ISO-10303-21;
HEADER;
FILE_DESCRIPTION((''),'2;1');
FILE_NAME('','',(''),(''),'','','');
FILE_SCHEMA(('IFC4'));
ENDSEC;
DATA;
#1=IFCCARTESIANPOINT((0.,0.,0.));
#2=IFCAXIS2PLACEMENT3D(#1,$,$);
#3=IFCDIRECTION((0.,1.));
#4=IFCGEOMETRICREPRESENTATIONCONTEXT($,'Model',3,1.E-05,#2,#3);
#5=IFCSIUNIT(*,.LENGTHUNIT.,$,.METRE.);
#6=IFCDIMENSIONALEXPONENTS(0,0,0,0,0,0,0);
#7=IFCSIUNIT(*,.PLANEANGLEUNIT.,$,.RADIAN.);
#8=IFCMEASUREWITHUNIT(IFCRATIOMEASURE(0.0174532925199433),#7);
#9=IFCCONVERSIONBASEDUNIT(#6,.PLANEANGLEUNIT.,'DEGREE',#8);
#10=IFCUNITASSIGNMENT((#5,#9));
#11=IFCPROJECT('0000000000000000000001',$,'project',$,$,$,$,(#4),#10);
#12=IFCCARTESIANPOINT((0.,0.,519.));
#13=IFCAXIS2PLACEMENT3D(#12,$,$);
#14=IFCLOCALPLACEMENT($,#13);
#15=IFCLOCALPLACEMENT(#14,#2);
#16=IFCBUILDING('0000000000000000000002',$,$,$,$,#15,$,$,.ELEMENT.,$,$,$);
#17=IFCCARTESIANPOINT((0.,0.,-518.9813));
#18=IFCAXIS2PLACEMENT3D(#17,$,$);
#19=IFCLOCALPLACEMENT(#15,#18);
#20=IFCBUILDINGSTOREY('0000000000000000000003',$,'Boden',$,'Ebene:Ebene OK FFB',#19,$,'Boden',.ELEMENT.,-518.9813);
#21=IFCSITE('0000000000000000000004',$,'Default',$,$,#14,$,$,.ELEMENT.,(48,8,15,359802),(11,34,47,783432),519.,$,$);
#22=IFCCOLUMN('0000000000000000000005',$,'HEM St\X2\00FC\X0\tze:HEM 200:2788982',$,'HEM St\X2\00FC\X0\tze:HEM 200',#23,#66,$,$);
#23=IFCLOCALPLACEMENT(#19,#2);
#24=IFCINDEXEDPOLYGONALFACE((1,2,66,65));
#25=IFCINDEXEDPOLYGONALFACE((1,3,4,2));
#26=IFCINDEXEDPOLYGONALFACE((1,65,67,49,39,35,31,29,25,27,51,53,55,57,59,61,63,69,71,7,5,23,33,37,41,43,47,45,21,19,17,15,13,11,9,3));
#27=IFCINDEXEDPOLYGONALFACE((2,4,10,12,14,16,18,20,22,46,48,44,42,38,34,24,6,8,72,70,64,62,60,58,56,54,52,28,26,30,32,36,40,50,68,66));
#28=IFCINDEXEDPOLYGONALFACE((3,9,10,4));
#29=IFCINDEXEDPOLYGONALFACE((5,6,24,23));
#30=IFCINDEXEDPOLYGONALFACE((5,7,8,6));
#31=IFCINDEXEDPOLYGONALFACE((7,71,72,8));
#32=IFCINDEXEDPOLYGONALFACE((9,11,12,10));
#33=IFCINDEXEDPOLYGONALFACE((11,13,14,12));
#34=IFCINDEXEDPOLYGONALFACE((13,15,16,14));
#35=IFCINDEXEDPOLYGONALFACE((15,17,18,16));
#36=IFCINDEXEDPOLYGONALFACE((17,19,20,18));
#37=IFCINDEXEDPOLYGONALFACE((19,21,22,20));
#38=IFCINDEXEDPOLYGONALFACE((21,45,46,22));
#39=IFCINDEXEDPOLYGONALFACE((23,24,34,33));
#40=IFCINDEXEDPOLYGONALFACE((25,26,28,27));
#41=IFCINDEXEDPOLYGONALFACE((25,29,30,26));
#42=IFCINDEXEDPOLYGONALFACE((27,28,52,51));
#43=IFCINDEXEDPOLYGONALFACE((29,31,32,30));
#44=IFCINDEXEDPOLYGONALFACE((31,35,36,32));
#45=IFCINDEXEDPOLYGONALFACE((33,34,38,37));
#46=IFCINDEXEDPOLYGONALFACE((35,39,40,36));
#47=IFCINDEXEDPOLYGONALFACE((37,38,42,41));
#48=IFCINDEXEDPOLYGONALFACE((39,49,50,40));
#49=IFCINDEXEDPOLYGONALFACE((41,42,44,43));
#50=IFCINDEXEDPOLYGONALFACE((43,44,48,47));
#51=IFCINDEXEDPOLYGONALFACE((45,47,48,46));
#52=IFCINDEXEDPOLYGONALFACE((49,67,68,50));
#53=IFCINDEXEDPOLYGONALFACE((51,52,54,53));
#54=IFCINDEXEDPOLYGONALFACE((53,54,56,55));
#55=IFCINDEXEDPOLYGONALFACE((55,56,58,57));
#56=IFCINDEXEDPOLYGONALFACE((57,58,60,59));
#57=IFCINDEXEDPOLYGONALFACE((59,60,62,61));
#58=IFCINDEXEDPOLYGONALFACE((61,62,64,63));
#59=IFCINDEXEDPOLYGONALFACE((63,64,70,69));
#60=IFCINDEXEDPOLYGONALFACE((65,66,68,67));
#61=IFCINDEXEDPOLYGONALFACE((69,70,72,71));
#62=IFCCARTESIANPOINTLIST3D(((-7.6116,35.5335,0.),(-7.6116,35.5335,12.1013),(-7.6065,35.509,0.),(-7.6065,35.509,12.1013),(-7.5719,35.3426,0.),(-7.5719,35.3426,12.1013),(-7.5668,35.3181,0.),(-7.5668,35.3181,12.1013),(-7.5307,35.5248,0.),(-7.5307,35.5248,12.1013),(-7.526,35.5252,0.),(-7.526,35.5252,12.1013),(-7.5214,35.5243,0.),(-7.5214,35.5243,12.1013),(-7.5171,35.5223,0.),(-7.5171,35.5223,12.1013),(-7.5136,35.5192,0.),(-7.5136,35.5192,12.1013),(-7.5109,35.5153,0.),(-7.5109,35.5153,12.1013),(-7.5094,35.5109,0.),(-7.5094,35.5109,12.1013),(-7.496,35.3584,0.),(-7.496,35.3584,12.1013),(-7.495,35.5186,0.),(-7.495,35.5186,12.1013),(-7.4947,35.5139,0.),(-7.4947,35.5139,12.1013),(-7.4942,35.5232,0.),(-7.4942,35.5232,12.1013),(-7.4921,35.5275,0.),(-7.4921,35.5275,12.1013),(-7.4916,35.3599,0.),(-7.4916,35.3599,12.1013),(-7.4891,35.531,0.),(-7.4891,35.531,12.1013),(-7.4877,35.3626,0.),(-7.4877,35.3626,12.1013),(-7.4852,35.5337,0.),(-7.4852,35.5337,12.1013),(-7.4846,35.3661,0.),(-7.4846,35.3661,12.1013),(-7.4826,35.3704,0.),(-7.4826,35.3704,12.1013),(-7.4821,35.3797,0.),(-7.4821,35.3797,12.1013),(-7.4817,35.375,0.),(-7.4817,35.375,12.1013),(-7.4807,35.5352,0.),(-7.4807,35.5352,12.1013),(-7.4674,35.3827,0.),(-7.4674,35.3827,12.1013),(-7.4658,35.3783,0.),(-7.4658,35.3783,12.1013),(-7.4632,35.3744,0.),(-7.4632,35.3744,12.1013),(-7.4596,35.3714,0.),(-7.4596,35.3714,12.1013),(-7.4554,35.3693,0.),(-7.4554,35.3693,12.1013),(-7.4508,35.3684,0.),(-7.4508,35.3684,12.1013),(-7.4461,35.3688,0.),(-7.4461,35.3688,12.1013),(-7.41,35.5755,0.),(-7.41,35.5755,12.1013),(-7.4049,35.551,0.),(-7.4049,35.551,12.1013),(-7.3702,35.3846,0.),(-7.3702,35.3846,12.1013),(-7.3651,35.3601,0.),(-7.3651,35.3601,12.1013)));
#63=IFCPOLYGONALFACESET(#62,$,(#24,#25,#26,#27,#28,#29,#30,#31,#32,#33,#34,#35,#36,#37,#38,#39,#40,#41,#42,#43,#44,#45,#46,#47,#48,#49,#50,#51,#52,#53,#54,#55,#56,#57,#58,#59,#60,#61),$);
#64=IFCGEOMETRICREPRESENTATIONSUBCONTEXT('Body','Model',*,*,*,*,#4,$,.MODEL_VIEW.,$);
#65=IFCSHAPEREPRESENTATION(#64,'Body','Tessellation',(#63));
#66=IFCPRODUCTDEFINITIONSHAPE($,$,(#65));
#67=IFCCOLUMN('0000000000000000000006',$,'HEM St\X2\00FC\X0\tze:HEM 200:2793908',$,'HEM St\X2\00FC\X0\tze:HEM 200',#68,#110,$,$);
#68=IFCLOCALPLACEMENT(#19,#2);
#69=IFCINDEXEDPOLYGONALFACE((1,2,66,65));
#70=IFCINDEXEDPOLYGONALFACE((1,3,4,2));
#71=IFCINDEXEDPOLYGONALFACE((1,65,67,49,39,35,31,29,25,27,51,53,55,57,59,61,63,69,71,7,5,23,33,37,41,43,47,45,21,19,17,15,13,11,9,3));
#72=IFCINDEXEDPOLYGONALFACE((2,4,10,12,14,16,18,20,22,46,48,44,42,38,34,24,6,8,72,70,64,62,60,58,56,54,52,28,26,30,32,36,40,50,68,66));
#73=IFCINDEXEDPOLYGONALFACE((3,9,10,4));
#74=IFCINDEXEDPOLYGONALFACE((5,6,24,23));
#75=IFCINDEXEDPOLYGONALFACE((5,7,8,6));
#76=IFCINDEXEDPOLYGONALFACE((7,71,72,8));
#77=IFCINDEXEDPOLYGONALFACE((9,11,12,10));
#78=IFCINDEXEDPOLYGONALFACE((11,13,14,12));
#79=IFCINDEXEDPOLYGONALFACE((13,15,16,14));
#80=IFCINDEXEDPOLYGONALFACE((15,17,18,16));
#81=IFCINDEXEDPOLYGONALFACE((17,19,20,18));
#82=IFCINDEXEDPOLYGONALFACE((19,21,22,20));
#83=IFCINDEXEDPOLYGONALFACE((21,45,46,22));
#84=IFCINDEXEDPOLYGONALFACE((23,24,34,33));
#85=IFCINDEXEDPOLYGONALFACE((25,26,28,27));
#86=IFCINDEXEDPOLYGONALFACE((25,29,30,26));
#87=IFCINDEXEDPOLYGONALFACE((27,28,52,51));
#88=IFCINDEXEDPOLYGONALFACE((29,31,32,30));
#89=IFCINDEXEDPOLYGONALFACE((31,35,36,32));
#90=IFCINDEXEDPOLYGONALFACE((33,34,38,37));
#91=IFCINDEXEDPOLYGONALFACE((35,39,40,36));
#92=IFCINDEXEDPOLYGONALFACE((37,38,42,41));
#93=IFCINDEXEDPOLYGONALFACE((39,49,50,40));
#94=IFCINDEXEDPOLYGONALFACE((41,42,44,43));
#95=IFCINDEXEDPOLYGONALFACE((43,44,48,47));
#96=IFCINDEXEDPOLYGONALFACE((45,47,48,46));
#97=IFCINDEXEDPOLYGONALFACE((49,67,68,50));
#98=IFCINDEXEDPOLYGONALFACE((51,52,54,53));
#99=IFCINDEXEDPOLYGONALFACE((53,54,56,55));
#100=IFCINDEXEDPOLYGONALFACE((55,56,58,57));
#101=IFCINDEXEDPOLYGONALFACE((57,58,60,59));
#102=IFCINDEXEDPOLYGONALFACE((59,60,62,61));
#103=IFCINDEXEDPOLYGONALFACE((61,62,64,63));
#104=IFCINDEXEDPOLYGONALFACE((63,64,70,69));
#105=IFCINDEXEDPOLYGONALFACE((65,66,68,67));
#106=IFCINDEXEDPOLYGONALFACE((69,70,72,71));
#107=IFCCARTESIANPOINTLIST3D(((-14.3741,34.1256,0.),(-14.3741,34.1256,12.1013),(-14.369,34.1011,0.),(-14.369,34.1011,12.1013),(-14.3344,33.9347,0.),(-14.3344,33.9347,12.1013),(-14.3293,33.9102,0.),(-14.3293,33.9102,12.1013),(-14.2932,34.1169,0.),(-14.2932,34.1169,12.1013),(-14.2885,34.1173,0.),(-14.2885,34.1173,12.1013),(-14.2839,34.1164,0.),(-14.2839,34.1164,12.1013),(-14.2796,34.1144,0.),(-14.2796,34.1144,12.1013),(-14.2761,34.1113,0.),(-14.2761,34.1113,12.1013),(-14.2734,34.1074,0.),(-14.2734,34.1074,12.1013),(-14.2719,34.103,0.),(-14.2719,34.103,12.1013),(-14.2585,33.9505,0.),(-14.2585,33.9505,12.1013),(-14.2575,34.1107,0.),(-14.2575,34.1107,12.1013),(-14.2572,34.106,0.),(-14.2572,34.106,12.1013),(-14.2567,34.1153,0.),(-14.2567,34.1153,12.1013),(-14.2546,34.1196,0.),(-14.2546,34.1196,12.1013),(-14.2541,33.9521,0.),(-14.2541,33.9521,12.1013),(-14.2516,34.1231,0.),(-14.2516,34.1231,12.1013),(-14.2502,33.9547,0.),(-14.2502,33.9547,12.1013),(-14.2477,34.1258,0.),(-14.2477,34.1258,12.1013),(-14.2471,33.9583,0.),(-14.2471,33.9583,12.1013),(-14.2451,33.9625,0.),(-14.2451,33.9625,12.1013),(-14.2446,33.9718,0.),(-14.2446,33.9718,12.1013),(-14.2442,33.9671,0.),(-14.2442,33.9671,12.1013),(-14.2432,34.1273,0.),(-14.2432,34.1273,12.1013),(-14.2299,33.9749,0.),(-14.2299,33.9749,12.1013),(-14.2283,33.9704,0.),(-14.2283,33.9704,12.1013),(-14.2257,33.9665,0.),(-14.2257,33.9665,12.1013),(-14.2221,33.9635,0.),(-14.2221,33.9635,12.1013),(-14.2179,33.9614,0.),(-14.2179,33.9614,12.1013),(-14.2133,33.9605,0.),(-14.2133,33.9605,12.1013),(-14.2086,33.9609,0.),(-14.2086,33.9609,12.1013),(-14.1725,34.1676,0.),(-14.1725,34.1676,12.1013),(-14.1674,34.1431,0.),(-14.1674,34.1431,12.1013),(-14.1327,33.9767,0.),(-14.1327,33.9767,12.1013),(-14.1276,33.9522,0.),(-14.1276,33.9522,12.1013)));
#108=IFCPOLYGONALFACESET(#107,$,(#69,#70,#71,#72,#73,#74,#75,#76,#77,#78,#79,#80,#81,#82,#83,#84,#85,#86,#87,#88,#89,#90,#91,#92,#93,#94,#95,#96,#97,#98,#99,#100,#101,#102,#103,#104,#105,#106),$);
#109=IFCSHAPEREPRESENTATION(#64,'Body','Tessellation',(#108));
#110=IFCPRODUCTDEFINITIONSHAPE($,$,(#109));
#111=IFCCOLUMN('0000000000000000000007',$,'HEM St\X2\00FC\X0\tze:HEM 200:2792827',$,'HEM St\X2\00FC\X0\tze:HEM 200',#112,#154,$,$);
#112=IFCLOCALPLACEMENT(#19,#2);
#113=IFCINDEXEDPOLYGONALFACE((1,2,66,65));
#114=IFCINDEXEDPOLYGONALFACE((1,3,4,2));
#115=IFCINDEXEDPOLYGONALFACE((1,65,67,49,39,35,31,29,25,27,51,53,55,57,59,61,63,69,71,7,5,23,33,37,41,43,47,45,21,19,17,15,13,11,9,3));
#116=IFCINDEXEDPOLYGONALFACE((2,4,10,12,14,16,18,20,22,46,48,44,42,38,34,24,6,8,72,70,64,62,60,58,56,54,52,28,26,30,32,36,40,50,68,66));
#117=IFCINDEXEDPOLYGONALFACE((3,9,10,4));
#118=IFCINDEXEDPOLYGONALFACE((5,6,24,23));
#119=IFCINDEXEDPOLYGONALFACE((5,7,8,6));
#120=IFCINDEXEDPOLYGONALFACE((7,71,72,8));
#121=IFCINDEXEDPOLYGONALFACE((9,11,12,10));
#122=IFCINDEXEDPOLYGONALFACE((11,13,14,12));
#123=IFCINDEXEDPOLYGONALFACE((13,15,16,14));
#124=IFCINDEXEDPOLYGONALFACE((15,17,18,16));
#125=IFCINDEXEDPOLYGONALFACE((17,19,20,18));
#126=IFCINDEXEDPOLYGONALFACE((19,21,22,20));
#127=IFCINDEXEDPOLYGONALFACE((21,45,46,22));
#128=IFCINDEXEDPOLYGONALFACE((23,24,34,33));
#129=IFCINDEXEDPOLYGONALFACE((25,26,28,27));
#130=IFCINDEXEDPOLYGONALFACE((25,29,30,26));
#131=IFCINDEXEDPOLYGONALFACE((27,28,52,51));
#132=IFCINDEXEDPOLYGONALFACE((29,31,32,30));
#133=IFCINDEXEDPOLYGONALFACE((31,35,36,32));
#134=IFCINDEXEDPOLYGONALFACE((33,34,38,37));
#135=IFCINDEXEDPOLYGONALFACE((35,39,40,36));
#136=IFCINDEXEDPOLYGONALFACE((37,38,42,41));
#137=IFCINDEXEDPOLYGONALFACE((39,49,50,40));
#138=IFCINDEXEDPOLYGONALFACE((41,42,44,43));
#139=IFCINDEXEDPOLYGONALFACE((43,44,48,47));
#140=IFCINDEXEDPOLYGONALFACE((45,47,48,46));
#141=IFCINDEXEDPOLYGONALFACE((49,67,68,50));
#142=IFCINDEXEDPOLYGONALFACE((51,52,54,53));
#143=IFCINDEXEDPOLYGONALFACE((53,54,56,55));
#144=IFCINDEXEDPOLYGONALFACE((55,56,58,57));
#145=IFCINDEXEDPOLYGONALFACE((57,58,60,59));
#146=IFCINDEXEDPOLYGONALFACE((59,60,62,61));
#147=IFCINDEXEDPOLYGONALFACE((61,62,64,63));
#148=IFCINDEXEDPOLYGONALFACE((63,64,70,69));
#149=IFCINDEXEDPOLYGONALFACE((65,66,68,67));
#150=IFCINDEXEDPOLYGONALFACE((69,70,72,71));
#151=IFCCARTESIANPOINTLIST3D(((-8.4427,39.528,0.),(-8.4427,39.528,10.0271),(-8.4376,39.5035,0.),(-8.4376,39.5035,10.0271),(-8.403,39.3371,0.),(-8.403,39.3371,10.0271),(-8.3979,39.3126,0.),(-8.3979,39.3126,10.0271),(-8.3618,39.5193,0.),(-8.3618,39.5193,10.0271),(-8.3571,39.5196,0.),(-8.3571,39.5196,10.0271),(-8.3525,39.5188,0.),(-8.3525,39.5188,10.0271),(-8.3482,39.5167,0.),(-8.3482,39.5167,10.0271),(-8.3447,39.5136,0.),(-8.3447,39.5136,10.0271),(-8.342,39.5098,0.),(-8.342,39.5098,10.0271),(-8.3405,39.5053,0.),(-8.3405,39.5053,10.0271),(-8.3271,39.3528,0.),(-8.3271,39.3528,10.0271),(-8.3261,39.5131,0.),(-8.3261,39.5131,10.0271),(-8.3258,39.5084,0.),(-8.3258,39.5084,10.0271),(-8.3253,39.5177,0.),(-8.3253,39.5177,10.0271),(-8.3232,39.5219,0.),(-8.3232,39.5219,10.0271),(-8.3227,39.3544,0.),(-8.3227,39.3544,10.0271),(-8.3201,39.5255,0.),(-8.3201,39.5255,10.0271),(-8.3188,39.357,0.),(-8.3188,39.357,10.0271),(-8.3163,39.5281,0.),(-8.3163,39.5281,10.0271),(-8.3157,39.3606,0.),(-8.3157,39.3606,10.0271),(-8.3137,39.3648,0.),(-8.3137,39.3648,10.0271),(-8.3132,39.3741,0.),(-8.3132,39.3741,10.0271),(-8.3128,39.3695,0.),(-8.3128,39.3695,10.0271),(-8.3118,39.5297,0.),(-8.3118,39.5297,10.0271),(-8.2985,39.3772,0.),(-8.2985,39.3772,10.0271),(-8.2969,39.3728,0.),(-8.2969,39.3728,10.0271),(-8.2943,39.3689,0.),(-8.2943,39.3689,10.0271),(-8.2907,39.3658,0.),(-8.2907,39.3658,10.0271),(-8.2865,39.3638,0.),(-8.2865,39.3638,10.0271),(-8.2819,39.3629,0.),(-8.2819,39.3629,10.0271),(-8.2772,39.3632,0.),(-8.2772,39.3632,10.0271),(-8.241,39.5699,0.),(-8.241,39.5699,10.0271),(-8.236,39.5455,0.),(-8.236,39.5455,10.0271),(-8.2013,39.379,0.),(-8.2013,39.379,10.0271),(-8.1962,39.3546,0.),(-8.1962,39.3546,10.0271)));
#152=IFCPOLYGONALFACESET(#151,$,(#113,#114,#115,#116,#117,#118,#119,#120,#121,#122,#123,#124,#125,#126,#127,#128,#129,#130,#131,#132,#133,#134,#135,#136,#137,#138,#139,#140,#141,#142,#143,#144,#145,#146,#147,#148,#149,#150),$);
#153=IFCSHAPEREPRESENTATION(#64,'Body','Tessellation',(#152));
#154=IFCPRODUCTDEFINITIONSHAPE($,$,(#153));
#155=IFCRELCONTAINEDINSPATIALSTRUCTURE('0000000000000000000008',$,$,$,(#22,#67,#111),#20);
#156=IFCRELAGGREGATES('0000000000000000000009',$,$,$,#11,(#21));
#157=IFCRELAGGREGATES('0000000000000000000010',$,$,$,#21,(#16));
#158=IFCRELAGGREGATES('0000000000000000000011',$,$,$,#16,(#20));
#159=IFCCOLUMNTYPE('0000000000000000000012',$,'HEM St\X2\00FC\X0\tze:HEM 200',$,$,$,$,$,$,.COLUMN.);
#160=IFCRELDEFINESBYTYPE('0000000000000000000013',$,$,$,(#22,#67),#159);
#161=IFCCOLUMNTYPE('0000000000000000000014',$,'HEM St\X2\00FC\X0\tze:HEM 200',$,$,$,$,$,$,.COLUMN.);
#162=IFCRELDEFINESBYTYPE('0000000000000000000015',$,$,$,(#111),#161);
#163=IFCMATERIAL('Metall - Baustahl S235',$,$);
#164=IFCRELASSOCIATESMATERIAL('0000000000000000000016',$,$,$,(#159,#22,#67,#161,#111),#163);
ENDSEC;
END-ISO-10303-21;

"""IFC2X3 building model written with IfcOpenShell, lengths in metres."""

from ifc_helpers import new_model, entity, si_unit, converted_unit, direction, frame, frame_2d, origin, place, context, subcontext, project, spatial, polyline, circle_curve, parameter, trimmed, segment, composite_curve, outline, extrude, source, transform, mapped, material, type_object, type_shapes, element, save


model = new_model("IFC2X3")

# Units and contexts
model_context = context("Model", 3, precision=1e-05, world=origin(), true_north=direction((0.0, 1.0)))
body_context = subcontext(model_context, "Body", "Model", "MODEL_VIEW")
ifc_project = project(units=[si_unit("LENGTHUNIT", "METRE"), converted_unit("PLANEANGLEUNIT", "DEGREE", entity("IfcRatioMeasure", 0.0174532925199433), si_unit("PLANEANGLEUNIT", "RADIAN"), dimensions=[0, 0, 0, 0, 0, 0, 0])], contexts=[model_context])

# Site, building, storey
site_placement = place(None, frame((0.0, 0.0, 519.0)))
site = spatial("IfcSite", under=ifc_project, at=site_placement, Name="Default", CompositionType="ELEMENT", RefLatitude=(48, 8, 15, 359802), RefLongitude=(11, 34, 47, 783432), RefElevation=519.0)
building_placement = place(site_placement, origin())
building = spatial("IfcBuilding", under=site, at=building_placement, CompositionType="ELEMENT")
storey_placement = place(building_placement, frame((0.0, 0.0, -518.9813)))
storey = spatial("IfcBuildingStorey", under=building, at=storey_placement, Name="Boden", ObjectType="Ebene:Ebene OK FFB", LongName="Boden", CompositionType="ELEMENT", Elevation=-518.9813)

# Columns
ifc_material = material(Name="Metall - Baustahl S235")
column_type_1 = type_object("IfcColumnType", Name="HEM Stütze:HEM 200", PredefinedType="COLUMN", material=ifc_material)
shared_shape_1 = source(origin(), body_context, "Body", "SweptSolid", [
    extrude(outline(composite_curve([segment(polyline([(0.085, -0.103), (0.11, -0.103)]), True, "CONTINUOUS"), segment(polyline([(0.11, -0.103), (0.11, 0.103)]), True, "CONTINUOUS"), segment(polyline([(0.11, 0.103), (0.085, 0.103)]), True, "CONTINUOUS"), segment(polyline([(0.085, 0.103), (0.085, 0.0255)]), True, "CONTINUOUS"), segment(trimmed(circle_curve(frame_2d((0.067, 0.0255), x_axis=(1.0, 0.0)), 0.018), [parameter(270.0)], [parameter(0.0)], True, "PARAMETER"), False, "CONTINUOUS"), segment(polyline([(0.067, 0.0075), (-0.067, 0.0075)]), True, "CONTINUOUS"), segment(trimmed(circle_curve(frame_2d((-0.067, 0.0255), x_axis=(0.0, -1.0)), 0.018), [parameter(270.0)], [parameter(0.0)], True, "PARAMETER"), False, "CONTINUOUS"), segment(polyline([(-0.085, 0.0255), (-0.085, 0.103)]), True, "CONTINUOUS"), segment(polyline([(-0.085, 0.103), (-0.11, 0.103)]), True, "CONTINUOUS"), segment(polyline([(-0.11, 0.103), (-0.11, -0.103)]), True, "CONTINUOUS"), segment(polyline([(-0.11, -0.103), (-0.085, -0.103)]), True, "CONTINUOUS"), segment(polyline([(-0.085, -0.103), (-0.085, -0.0255)]), True, "CONTINUOUS"), segment(trimmed(circle_curve(frame_2d((-0.067, -0.0255), x_axis=(-1.0, 0.0)), 0.018), [parameter(270.0)], [parameter(0.0)], True, "PARAMETER"), False, "CONTINUOUS"), segment(polyline([(-0.067, -0.0075), (0.067, -0.0075)]), True, "CONTINUOUS"), segment(trimmed(circle_curve(frame_2d((0.067, -0.0255), x_axis=(0.0, 1.0)), 0.018), [parameter(270.0)], [parameter(0.0)], True, "PARAMETER"), False, "CONTINUOUS"), segment(polyline([(0.085, -0.0255), (0.085, -0.103)]), True, "CONTINUOUS")], self_intersect=False)), frame((0.0, 0.0, -518.9813), z_axis=(0.0, 0.0, 1.0), x_axis=(0.0, -1.0, 0.0)), (0.0, 0.0, 1.0), 12.1013),
])
type_shapes(column_type_1, [shared_shape_1])
for number, where, z_axis, x_axis, name in (
    (1, (-7.4884, 35.4468, 518.9813), (0.0, 0.0, 1.0), (0.979008, 0.20382, 0.0), "HEM Stütze:HEM 200:2788982"),
    (2, (-14.2509, 34.0389, 518.9813), (0.0, 0.0, 1.0), (0.979008, 0.20382, 0.0), "HEM Stütze:HEM 200:2793908"),
):
    element("IfcColumn", number, at=place(storey_placement, frame(where, z_axis=z_axis, x_axis=x_axis)), inside=storey, type_object=column_type_1, material=ifc_material, Name=name, ObjectType="HEM Stütze:HEM 200", context=body_context, shape_type="MappedRepresentation", body=[
        mapped(shared_shape_1, transform((0.0, 0.0, 0.0), scale=1.0)),
    ])
column_type_2 = type_object("IfcColumnType", Name="HEM Stütze:HEM 200", PredefinedType="COLUMN", material=ifc_material)
shared_shape_2 = source(origin(), body_context, "Body", "SweptSolid", [
    extrude(outline(composite_curve([segment(polyline([(0.085, -0.103), (0.11, -0.103)]), True, "CONTINUOUS"), segment(polyline([(0.11, -0.103), (0.11, 0.103)]), True, "CONTINUOUS"), segment(polyline([(0.11, 0.103), (0.085, 0.103)]), True, "CONTINUOUS"), segment(polyline([(0.085, 0.103), (0.085, 0.0255)]), True, "CONTINUOUS"), segment(trimmed(circle_curve(frame_2d((0.067, 0.0255), x_axis=(1.0, 0.0)), 0.018), [parameter(270.0)], [parameter(0.0)], True, "PARAMETER"), False, "CONTINUOUS"), segment(polyline([(0.067, 0.0075), (-0.067, 0.0075)]), True, "CONTINUOUS"), segment(trimmed(circle_curve(frame_2d((-0.067, 0.0255), x_axis=(0.0, -1.0)), 0.018), [parameter(270.0)], [parameter(0.0)], True, "PARAMETER"), False, "CONTINUOUS"), segment(polyline([(-0.085, 0.0255), (-0.085, 0.103)]), True, "CONTINUOUS"), segment(polyline([(-0.085, 0.103), (-0.11, 0.103)]), True, "CONTINUOUS"), segment(polyline([(-0.11, 0.103), (-0.11, -0.103)]), True, "CONTINUOUS"), segment(polyline([(-0.11, -0.103), (-0.085, -0.103)]), True, "CONTINUOUS"), segment(polyline([(-0.085, -0.103), (-0.085, -0.0255)]), True, "CONTINUOUS"), segment(trimmed(circle_curve(frame_2d((-0.067, -0.0255), x_axis=(-1.0, 0.0)), 0.018), [parameter(270.0)], [parameter(0.0)], True, "PARAMETER"), False, "CONTINUOUS"), segment(polyline([(-0.067, -0.0075), (0.067, -0.0075)]), True, "CONTINUOUS"), segment(trimmed(circle_curve(frame_2d((0.067, -0.0255), x_axis=(0.0, 1.0)), 0.018), [parameter(270.0)], [parameter(0.0)], True, "PARAMETER"), False, "CONTINUOUS"), segment(polyline([(0.085, -0.0255), (0.085, -0.103)]), True, "CONTINUOUS")], self_intersect=False)), frame((-8.3195, 39.4413, -518.9813), z_axis=(0.0, 0.0, 1.0), x_axis=(-0.20382, 0.979008, 0.0)), (0.0, 0.0, 1.0), 10.0271),
])
type_shapes(column_type_2, [shared_shape_2])
column_1_placement = place(storey_placement, frame((0.0, 0.0, 518.9813)))
element("IfcColumn", 3, at=column_1_placement, inside=storey, type_object=column_type_2, material=ifc_material, Name="HEM Stütze:HEM 200:2792827", ObjectType="HEM Stütze:HEM 200", context=body_context, shape_type="MappedRepresentation", body=[
    mapped(shared_shape_2, transform((0.0, 0.0, 0.0), scale=1.0)),
])

save(model, "model.ifc")
